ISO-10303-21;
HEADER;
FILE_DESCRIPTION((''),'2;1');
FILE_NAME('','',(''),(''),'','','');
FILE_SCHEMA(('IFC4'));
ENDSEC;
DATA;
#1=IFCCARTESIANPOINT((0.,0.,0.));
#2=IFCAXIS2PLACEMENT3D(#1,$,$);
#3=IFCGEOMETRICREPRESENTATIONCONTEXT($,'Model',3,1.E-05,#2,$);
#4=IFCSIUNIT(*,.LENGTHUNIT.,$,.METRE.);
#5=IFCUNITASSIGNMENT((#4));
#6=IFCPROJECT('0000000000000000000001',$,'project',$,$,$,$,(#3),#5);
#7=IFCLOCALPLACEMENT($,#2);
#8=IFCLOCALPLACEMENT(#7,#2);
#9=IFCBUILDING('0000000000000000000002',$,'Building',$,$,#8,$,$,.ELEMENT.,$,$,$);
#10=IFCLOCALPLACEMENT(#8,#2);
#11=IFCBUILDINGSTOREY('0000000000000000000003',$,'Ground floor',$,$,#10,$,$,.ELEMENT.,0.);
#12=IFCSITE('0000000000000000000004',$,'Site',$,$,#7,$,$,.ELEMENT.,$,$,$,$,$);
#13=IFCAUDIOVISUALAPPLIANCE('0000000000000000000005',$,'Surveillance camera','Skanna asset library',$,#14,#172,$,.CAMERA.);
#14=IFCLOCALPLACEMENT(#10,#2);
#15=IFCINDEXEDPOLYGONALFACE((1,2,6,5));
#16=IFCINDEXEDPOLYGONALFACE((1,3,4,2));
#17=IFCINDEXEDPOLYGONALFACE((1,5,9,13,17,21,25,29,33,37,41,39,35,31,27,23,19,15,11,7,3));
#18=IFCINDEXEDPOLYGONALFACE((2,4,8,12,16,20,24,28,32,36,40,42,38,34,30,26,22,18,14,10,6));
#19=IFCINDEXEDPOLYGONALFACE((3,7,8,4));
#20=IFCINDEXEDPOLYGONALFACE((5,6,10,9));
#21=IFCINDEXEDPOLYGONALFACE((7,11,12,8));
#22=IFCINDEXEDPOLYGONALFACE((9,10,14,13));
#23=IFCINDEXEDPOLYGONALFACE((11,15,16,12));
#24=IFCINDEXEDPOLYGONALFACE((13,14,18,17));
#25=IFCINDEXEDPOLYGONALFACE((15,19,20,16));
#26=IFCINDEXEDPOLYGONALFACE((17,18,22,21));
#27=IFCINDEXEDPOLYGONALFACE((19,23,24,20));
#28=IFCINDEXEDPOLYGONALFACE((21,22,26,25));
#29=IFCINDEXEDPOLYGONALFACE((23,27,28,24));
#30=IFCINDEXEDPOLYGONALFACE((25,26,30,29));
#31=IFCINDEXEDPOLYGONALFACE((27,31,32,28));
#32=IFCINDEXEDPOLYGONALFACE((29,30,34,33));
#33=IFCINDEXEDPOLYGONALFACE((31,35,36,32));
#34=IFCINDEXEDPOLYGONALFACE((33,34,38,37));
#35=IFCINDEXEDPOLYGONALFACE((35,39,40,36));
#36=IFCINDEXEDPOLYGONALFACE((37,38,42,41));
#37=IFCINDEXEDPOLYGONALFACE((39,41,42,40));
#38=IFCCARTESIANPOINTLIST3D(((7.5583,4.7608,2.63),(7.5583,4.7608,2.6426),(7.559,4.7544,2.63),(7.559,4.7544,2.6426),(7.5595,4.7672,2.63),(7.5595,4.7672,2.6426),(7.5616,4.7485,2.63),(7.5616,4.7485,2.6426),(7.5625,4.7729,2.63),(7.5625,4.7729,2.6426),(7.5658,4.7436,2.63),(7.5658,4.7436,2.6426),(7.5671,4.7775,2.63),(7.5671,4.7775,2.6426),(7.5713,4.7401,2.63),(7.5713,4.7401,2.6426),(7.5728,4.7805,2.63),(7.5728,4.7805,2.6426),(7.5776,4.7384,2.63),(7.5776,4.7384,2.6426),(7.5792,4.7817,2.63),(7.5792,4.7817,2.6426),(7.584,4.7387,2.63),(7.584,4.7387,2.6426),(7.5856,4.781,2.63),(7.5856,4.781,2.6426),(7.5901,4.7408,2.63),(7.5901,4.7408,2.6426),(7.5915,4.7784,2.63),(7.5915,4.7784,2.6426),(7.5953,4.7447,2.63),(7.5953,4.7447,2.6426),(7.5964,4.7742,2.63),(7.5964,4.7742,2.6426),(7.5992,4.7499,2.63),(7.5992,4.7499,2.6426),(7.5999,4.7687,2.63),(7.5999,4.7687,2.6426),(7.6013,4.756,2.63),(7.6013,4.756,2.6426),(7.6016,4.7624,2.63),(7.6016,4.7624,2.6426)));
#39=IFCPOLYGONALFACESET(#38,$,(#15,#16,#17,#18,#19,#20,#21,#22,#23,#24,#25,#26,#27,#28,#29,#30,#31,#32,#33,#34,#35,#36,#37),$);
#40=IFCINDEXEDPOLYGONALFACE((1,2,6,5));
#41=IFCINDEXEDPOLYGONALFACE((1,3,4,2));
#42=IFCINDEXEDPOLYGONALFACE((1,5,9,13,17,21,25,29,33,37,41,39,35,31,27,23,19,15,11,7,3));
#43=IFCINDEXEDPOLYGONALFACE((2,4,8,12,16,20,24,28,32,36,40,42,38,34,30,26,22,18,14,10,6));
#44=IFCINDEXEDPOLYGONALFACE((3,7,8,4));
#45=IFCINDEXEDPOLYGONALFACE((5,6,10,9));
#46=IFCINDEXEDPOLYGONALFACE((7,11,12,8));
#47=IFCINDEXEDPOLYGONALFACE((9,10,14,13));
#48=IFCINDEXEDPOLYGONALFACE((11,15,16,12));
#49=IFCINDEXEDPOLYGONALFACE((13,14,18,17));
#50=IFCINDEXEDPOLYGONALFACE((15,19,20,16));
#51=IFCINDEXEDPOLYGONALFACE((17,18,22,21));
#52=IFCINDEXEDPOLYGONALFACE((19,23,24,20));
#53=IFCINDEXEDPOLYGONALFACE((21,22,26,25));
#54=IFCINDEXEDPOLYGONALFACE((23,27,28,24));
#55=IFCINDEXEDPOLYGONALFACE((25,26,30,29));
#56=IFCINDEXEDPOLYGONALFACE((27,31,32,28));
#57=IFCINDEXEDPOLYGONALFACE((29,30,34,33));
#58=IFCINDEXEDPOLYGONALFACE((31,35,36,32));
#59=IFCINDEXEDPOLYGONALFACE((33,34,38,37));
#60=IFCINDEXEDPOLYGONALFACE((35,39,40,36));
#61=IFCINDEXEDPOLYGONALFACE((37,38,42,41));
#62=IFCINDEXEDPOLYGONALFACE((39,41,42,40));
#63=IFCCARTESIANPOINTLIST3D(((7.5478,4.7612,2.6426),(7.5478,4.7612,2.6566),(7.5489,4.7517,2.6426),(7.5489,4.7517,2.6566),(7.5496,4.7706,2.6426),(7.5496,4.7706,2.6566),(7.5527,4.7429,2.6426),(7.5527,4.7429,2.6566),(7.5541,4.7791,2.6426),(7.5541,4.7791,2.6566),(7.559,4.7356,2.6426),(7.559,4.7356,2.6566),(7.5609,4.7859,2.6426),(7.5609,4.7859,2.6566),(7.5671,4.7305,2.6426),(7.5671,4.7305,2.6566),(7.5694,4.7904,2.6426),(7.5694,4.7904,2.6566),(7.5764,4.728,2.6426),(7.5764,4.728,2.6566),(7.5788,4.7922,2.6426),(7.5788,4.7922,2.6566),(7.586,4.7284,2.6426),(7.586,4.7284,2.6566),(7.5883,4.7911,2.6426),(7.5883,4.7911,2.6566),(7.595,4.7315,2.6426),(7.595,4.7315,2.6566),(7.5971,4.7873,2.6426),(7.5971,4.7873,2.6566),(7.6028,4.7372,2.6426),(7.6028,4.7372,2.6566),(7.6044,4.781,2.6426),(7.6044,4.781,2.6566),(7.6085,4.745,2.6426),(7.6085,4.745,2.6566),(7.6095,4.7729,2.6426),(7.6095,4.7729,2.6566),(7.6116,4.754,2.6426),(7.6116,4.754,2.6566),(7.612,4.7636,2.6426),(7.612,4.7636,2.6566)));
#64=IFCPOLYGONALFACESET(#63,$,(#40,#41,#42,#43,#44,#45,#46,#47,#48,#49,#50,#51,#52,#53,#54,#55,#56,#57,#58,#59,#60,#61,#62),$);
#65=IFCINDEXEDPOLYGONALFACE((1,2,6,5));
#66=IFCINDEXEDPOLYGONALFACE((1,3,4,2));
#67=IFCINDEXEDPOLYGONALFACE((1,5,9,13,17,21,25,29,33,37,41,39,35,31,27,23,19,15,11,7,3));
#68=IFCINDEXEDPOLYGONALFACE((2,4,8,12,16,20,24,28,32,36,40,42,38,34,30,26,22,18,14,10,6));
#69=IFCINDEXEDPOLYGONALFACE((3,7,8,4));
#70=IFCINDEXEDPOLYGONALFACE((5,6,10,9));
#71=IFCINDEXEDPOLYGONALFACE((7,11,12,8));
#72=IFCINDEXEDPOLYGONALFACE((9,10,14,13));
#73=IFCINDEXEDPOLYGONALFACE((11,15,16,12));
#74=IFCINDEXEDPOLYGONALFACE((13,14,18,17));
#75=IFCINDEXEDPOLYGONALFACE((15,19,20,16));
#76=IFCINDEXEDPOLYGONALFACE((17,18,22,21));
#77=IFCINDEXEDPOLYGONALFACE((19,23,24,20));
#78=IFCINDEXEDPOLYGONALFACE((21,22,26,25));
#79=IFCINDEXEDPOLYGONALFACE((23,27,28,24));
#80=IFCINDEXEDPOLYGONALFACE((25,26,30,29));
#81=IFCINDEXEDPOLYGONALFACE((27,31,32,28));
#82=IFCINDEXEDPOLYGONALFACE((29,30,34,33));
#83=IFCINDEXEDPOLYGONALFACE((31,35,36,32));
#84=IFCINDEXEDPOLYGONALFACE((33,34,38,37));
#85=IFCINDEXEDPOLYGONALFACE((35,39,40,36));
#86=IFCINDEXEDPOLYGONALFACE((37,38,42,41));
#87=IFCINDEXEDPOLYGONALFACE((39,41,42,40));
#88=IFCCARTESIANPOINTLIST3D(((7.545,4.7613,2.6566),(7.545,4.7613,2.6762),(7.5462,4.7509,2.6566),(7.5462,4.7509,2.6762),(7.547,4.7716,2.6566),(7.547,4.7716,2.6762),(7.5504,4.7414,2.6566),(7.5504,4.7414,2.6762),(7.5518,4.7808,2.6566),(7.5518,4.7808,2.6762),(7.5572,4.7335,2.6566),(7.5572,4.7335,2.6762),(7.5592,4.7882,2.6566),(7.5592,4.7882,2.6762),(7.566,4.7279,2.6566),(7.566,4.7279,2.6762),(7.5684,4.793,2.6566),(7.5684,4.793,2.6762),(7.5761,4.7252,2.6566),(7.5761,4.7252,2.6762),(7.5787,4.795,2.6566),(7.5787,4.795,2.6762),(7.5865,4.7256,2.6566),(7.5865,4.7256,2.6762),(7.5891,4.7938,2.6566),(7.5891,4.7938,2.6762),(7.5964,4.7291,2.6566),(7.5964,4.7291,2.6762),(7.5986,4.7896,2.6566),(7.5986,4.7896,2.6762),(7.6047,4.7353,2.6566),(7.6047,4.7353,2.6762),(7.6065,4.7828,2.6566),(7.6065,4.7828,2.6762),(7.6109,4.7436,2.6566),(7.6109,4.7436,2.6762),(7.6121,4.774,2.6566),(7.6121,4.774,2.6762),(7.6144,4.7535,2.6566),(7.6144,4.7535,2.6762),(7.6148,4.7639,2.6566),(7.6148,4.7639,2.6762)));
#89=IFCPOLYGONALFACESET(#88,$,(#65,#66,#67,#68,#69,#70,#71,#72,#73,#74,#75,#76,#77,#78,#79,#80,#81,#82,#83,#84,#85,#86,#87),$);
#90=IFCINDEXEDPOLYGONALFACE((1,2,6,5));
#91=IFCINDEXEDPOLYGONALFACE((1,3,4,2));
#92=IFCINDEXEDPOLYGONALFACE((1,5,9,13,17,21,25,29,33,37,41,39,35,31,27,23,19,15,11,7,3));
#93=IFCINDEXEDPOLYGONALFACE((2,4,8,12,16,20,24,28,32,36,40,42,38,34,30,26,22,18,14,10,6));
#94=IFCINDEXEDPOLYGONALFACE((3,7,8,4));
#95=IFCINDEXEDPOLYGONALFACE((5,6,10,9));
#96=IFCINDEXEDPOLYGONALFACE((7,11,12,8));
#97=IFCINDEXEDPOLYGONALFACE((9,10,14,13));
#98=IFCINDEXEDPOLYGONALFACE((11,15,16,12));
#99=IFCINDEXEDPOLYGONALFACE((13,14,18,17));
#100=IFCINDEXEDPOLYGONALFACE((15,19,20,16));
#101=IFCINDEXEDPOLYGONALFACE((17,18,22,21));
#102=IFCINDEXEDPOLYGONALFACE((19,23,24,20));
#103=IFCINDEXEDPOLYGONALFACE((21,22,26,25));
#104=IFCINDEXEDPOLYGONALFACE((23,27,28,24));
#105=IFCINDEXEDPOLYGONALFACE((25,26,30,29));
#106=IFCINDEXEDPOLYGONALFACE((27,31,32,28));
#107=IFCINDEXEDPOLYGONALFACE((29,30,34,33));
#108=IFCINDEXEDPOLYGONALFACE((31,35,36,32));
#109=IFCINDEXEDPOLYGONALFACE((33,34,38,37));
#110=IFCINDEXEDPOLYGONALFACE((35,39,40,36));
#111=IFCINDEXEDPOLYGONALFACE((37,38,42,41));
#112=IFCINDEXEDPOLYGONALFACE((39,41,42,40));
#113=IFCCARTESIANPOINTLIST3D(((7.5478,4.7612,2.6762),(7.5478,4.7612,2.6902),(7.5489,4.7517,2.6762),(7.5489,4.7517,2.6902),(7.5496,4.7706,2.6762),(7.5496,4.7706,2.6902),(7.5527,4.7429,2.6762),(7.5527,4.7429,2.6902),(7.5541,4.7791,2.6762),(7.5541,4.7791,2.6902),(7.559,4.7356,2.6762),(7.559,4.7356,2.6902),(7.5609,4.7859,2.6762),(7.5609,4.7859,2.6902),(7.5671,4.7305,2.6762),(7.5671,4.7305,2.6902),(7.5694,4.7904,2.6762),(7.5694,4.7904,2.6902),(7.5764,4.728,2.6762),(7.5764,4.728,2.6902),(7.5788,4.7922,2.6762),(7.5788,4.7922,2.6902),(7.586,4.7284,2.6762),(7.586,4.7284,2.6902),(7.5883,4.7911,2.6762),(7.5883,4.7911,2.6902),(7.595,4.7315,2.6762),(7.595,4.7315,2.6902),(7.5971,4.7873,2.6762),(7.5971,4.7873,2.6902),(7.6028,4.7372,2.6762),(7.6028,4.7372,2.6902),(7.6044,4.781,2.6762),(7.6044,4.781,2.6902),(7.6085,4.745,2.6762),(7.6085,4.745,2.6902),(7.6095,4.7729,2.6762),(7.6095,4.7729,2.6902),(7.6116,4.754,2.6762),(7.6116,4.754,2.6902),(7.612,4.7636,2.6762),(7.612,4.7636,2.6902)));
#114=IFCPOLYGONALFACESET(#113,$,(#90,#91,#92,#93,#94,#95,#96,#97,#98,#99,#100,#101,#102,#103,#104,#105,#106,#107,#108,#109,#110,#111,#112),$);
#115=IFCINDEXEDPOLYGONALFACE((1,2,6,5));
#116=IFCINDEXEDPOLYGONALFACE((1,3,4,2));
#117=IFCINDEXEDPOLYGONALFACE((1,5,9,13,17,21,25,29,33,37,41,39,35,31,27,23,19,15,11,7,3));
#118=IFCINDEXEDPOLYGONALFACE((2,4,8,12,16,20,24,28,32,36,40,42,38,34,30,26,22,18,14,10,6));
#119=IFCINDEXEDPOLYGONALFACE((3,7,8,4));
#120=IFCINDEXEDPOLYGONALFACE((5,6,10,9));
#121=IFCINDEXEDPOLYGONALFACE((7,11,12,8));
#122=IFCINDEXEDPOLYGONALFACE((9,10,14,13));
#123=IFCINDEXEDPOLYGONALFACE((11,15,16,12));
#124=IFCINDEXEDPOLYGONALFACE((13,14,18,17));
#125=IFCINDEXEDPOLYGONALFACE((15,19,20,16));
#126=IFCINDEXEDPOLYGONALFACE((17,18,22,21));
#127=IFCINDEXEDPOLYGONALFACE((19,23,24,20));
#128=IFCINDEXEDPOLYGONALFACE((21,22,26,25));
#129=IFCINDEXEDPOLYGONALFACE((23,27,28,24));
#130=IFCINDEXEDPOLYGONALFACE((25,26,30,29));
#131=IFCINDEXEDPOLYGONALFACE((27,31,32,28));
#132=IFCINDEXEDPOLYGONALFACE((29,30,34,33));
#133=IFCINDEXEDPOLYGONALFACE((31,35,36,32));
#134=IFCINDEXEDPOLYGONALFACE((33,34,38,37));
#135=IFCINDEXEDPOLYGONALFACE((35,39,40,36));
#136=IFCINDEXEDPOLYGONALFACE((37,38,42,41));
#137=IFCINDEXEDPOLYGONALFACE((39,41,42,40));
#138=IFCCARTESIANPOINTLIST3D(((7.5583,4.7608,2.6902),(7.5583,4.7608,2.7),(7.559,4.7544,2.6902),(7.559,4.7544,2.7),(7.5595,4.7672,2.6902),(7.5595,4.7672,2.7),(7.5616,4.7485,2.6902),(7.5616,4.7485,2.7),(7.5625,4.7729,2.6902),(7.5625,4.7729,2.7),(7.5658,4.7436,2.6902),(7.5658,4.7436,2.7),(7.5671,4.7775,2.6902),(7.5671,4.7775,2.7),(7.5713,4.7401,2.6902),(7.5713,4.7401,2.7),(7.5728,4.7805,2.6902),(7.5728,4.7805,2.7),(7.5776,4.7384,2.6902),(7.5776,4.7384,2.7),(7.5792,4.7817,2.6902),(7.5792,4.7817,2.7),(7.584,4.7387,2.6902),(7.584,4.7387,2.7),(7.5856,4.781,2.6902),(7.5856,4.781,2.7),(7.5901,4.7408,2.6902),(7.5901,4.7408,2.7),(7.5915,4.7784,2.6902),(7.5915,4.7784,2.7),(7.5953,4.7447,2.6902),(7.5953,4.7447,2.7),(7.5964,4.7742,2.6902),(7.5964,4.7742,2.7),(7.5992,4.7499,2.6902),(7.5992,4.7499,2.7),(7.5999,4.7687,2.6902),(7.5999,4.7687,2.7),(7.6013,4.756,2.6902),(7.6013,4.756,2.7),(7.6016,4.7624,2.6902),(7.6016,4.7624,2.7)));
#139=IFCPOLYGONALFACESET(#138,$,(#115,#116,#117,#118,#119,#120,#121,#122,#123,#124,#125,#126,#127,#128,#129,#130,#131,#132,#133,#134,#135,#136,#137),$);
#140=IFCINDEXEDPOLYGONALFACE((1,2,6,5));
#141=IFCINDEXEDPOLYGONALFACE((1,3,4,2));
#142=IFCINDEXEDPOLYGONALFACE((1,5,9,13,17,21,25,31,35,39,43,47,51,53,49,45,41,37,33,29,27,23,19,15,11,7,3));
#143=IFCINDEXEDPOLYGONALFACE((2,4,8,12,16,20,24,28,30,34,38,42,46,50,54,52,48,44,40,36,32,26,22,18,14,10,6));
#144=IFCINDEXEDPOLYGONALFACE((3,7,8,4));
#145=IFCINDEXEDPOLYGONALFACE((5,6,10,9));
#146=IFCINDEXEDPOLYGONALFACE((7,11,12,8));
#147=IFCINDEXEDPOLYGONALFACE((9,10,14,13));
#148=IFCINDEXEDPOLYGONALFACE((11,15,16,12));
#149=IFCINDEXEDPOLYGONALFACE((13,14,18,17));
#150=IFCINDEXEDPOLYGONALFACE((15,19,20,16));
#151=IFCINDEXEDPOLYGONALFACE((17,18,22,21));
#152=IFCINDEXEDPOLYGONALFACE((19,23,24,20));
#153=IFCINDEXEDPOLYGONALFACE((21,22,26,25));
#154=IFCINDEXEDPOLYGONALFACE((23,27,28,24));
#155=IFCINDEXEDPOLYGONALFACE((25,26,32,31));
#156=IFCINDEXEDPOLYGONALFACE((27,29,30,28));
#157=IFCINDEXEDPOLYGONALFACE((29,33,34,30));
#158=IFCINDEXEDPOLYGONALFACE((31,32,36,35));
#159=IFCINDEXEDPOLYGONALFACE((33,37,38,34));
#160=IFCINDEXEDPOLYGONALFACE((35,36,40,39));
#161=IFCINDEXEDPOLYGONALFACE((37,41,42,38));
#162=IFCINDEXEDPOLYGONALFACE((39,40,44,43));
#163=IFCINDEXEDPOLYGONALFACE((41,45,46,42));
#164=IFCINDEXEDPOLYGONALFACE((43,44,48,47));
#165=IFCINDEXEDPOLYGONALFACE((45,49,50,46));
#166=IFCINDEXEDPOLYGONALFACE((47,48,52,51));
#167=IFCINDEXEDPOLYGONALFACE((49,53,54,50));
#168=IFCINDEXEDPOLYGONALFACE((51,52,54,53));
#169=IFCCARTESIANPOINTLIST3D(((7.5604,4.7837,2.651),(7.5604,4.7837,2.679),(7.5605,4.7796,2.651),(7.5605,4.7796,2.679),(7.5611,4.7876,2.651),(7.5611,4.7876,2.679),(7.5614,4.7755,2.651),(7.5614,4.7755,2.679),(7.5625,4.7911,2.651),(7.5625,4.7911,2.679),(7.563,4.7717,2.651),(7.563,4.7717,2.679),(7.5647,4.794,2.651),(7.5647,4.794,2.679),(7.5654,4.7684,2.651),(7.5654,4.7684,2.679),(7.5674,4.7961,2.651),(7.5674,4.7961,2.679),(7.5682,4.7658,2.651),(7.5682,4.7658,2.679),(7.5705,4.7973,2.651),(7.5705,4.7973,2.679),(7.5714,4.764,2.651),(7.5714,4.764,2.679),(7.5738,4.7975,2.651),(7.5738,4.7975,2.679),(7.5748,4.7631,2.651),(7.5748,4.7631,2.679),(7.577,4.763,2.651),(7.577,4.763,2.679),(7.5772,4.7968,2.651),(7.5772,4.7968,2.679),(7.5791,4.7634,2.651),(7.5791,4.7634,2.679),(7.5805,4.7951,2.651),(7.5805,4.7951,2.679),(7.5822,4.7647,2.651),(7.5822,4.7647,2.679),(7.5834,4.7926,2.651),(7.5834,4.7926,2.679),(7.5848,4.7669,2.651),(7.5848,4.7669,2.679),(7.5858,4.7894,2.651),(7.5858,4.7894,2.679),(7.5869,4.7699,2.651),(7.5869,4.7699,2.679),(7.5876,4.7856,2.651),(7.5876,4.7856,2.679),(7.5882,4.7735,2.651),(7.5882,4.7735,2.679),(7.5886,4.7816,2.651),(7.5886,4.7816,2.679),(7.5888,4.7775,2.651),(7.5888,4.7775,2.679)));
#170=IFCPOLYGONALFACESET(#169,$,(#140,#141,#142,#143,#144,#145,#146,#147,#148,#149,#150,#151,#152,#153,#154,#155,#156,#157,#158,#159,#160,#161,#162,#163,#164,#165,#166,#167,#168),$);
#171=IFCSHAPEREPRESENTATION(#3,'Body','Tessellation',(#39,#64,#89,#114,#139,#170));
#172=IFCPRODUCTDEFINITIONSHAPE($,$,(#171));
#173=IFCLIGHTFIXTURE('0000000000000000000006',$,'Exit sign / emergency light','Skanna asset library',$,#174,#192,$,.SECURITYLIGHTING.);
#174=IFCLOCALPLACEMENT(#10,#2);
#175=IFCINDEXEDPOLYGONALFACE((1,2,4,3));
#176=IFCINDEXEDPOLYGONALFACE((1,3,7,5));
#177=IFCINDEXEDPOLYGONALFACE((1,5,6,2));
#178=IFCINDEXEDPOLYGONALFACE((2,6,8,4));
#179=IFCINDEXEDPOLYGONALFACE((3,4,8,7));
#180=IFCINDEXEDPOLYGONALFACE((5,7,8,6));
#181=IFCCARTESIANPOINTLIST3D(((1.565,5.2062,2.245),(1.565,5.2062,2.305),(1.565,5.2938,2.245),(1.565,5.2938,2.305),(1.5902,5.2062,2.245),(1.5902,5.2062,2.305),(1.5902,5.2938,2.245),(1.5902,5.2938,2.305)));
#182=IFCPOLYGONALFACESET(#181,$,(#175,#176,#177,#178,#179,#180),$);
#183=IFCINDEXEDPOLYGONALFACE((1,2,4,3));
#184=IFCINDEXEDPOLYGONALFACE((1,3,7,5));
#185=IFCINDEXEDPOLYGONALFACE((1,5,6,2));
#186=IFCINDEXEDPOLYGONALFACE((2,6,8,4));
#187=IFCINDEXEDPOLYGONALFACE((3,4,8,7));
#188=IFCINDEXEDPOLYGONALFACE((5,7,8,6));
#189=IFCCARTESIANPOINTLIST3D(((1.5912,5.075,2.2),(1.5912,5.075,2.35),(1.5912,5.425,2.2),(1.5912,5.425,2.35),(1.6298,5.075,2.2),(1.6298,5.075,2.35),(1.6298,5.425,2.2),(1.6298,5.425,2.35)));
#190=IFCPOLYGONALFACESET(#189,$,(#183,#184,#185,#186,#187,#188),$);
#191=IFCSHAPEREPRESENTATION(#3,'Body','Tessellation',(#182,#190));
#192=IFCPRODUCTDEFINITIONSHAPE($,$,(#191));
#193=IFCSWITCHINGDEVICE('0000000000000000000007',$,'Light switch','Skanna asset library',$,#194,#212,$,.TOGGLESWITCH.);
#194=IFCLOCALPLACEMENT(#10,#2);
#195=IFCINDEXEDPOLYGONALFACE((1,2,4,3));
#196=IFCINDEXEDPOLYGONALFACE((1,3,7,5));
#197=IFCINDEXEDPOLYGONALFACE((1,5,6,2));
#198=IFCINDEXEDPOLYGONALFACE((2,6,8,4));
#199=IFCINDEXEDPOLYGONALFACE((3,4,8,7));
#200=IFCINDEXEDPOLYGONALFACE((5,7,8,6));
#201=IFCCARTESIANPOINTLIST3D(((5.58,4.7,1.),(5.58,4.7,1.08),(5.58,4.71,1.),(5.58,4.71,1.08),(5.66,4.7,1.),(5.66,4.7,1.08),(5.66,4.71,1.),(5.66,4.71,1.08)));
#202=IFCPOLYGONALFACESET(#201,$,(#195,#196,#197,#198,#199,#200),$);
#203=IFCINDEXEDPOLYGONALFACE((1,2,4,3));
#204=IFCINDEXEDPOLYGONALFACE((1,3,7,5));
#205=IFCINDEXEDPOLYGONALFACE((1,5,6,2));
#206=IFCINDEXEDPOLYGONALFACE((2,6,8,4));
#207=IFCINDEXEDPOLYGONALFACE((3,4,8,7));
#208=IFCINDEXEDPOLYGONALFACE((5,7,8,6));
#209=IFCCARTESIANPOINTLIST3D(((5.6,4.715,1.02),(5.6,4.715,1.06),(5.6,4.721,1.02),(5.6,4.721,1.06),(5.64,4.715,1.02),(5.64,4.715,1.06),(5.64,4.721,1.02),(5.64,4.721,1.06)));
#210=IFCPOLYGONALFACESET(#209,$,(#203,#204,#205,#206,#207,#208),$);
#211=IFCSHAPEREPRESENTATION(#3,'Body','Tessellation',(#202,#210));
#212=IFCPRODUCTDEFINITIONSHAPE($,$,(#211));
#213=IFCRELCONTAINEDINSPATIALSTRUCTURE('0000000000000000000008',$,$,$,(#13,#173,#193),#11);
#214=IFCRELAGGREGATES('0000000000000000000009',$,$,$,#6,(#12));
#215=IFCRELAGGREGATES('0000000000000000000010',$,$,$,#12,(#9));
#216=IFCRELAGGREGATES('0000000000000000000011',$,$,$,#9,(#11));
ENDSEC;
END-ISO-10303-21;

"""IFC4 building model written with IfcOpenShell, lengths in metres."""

from ifc_helpers import new_model, si_unit, frame, frame_2d, origin, origin_2d, place, context, project, spatial, rectangle, circle, ellipse, extrude, element, save


model = new_model("IFC4")

# Units and contexts
model_context = context("Model", 3, precision=1e-05, world=origin())
ifc_project = project(units=[si_unit("LENGTHUNIT", "METRE")], contexts=[model_context])

# Site, building, storey
site_placement = place(None, origin())
site = spatial("IfcSite", under=ifc_project, at=site_placement, Name="Site", CompositionType="ELEMENT")
building_placement = place(site_placement, origin())
building = spatial("IfcBuilding", under=site, at=building_placement, Name="Building", CompositionType="ELEMENT")
storey_placement = place(building_placement, origin())
storey = spatial("IfcBuildingStorey", under=building, at=storey_placement, Name="Ground floor", CompositionType="ELEMENT", Elevation=0.0)

# Audio visual appliance
audio_visual_appliance_placement = place(storey_placement, frame((7.58, 4.76, 2.63), z_axis=(0.0, 0.0, 1.0), x_axis=(-0.965926, -0.258819, 0.0)))
element("IfcAudioVisualAppliance", 1, at=audio_visual_appliance_placement, inside=storey, Name="Surveillance camera", Description="Skanna asset library", PredefinedType="CAMERA", context=model_context, shape_type="SweptSolid", body=[
    extrude(circle(Radius=0.0217, at=origin_2d()), origin(), (0.0, 0.0, 1.0), 0.0126),
    extrude(circle(Radius=0.0322, at=origin_2d()), frame((0.0, 0.0, 0.0126)), (0.0, 0.0, 1.0), 0.014),
    extrude(circle(Radius=0.035, at=origin_2d()), frame((0.0, 0.0, 0.0266)), (0.0, 0.0, 1.0), 0.0196),
    extrude(circle(Radius=0.0322, at=origin_2d()), frame((0.0, 0.0, 0.0462)), (0.0, 0.0, 1.0), 0.014),
    extrude(circle(Radius=0.0217, at=origin_2d()), frame((0.0, 0.0, 0.0602)), (0.0, 0.0, 1.0), 0.0098),
    extrude(ellipse(SemiAxis1=0.014, SemiAxis2=0.0175, at=frame_2d((0.0, -0.021))), frame((0.0, 0.0, 0.021)), (0.0, 0.0, 1.0), 0.028),
])

# Light fixture
light_fixture_1_placement = place(storey_placement, frame((1.6, 5.25, 2.2), z_axis=(0.0, 0.0, 1.0), x_axis=(0.0, 1.0, 0.0)))
element("IfcLightFixture", 2, at=light_fixture_1_placement, inside=storey, Name="Exit sign / emergency light", Description="Skanna asset library", PredefinedType="SECURITYLIGHTING", context=model_context, shape_type="SweptSolid", body=[
    extrude(rectangle(XDim=0.0875, YDim=0.0252, at=frame_2d((0.0, 0.0224))), frame((0.0, 0.0, 0.045)), (0.0, 0.0, 1.0), 0.06),
    extrude(rectangle(XDim=0.35, YDim=0.0385, at=frame_2d((0.0, -0.0105))), origin(), (0.0, 0.0, 1.0), 0.15),
])

# Switching device
switching_device_placement = place(storey_placement, frame((5.62, 4.71, 1.0), z_axis=(0.0, 0.0, 1.0), x_axis=(-1.0, 0.0, 0.0)))
element("IfcSwitchingDevice", 3, at=switching_device_placement, inside=storey, Name="Light switch", Description="Skanna asset library", PredefinedType="TOGGLESWITCH", context=model_context, shape_type="SweptSolid", body=[
    extrude(rectangle(XDim=0.08, YDim=0.01, at=frame_2d((0.0, 0.005))), origin(), (0.0, 0.0, 1.0), 0.08),
    extrude(rectangle(XDim=0.04, YDim=0.006, at=frame_2d((0.0, -0.008))), frame((0.0, 0.0, 0.02)), (0.0, 0.0, 1.0), 0.04),
])

save(model, "model.ifc")
